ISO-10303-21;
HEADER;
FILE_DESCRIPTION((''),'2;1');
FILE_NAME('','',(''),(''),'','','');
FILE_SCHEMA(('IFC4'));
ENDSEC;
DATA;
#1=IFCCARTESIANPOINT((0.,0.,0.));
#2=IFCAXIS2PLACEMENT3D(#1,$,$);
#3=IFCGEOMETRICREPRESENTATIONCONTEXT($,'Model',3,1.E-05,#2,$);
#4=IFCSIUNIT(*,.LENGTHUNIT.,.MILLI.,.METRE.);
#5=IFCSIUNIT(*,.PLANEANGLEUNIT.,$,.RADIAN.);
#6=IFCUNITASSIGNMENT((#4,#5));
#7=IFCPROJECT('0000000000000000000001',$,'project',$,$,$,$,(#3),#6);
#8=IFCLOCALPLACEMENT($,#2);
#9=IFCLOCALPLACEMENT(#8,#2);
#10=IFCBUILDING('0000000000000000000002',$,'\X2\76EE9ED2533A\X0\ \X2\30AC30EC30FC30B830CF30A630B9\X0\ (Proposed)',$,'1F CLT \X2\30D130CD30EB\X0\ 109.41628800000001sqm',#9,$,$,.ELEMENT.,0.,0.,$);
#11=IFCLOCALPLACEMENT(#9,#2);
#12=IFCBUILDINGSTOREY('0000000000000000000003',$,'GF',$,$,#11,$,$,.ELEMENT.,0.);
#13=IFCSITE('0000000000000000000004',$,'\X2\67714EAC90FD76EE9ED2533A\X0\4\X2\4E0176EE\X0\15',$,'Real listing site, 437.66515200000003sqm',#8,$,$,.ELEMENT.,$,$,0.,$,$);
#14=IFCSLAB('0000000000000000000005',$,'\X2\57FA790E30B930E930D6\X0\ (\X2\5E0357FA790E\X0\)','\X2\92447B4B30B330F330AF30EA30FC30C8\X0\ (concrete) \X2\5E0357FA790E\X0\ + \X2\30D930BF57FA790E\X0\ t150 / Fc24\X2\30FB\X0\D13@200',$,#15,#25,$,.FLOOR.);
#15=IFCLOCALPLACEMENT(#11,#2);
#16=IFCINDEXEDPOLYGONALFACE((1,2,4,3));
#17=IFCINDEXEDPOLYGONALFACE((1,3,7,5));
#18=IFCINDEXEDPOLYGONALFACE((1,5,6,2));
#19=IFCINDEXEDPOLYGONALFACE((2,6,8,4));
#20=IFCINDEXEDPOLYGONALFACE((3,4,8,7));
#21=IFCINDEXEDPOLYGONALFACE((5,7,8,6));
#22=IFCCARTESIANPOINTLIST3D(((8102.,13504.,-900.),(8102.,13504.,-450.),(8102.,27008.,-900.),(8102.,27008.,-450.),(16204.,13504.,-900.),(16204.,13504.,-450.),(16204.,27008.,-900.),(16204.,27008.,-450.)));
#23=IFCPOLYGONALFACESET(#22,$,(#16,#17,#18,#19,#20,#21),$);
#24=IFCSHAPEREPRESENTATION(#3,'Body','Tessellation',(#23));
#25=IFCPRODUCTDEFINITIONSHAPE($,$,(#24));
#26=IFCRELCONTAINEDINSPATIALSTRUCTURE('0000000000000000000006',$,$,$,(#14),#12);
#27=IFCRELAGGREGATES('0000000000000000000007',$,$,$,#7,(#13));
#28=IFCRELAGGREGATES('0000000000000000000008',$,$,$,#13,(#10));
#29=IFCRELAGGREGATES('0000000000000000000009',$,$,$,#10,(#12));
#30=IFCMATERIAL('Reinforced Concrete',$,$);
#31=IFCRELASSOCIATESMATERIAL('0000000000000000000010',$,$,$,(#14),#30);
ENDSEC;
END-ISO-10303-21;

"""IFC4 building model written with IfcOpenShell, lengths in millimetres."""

from ifc_helpers import new_model, si_unit, frame, frame_2d, origin, place, context, project, spatial, rectangle, extrude, material, element, save


model = new_model("IFC4")

# Units and contexts
model_context = context("Model", 3, precision=1e-05, world=origin())
ifc_project = project(units=[si_unit("LENGTHUNIT", "METRE", prefix="MILLI"), si_unit("PLANEANGLEUNIT", "RADIAN")], contexts=[model_context])

# Site, building, storey
site_placement = place(None, origin())
site = spatial("IfcSite", under=ifc_project, at=site_placement, Name="東京都目黒区4丁目15", ObjectType="Real listing site, 437.66515200000003sqm", CompositionType="ELEMENT", RefElevation=0.0)
building_placement = place(site_placement, origin())
building = spatial("IfcBuilding", under=site, at=building_placement, Name="目黒区 ガレージハウス (Proposed)", ObjectType="1F CLT パネル 109.41628800000001sqm", CompositionType="ELEMENT", ElevationOfRefHeight=0.0, ElevationOfTerrain=0.0)
storey_placement = place(building_placement, origin())
storey = spatial("IfcBuildingStorey", under=building, at=storey_placement, Name="GF", CompositionType="ELEMENT", Elevation=0.0)

# Slab
ifc_material_1 = material(Name="Reinforced Concrete")
slab_1_placement = place(storey_placement, frame((4051.0, 6752.0, -450.0)))
element("IfcSlab", 1, at=slab_1_placement, inside=storey, material=ifc_material_1, Name="基礎スラブ (布基礎)", Description="鉄筋コンクリート (concrete) 布基礎 + ベタ基礎 t150 / Fc24・D13@200", PredefinedType="FLOOR", context=model_context, shape_type="SweptSolid", body=[
    extrude(rectangle(XDim=8102.0, YDim=13504.0, at=frame_2d((4051.0, 6752.0))), frame((4051.0, 6752.0, -450.0)), (0.0, 0.0, 1.0), 450.0),
])

save(model, "model.ifc")
